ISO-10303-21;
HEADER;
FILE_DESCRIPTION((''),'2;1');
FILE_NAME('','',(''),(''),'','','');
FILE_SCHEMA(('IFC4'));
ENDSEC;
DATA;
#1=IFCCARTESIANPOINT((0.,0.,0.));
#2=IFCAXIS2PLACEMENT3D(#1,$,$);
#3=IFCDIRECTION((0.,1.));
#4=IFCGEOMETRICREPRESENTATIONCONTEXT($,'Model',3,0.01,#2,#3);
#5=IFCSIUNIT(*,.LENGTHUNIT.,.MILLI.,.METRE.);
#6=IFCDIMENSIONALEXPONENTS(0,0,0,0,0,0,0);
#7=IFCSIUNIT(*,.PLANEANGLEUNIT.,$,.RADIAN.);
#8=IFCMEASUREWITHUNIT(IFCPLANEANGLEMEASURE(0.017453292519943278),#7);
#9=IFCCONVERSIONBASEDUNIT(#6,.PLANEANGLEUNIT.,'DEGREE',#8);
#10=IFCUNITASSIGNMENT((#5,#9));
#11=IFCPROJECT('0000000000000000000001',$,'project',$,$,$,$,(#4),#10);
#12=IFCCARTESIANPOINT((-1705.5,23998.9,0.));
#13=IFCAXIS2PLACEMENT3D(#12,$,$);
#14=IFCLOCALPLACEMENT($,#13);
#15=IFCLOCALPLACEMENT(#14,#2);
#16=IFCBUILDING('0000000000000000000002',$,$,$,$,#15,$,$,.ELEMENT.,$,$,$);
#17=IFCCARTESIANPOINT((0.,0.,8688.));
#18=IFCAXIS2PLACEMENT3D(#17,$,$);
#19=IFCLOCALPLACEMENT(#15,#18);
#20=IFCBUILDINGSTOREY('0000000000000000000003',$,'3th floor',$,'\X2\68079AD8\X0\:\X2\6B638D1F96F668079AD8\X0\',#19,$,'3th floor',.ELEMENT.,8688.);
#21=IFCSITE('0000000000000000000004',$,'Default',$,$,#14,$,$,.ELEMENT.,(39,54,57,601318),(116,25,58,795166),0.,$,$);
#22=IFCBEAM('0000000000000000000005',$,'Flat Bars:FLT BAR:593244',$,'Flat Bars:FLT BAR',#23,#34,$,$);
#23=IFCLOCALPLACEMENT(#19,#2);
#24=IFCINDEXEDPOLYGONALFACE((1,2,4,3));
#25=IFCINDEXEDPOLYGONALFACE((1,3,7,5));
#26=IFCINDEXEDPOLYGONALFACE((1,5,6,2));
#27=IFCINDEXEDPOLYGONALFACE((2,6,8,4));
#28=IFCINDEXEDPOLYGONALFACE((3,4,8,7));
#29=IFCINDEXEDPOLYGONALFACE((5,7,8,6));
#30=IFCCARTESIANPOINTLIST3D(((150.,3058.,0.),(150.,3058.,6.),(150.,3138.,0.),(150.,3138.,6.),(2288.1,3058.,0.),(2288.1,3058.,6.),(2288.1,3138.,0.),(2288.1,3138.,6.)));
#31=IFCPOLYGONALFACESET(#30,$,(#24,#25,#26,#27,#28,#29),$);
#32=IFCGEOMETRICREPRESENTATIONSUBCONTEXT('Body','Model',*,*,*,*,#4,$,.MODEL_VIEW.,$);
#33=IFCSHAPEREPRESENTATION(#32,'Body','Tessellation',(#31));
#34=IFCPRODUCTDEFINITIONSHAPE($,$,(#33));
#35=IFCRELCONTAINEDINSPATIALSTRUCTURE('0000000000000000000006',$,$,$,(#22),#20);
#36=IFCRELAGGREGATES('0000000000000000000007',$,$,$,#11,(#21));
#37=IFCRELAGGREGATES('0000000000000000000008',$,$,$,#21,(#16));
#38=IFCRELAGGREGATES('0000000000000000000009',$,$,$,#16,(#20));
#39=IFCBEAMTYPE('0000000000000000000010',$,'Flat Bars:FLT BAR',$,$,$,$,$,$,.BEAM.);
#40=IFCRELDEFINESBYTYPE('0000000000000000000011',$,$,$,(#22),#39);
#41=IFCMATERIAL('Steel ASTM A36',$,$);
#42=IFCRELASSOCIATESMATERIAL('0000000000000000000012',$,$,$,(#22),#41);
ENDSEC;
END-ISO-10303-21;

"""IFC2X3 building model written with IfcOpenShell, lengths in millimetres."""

from ifc_helpers import new_model, entity, si_unit, converted_unit, direction, frame, origin, origin_2d_with_axis, place, context, subcontext, project, spatial, rectangle, extrude, material, type_object, element, save


model = new_model("IFC2X3")

# Units and contexts
model_context = context("Model", 3, precision=0.01, world=origin(), true_north=direction((0.0, 1.0)))
body_context = subcontext(model_context, "Body", "Model", "MODEL_VIEW")
ifc_project = project(units=[si_unit("LENGTHUNIT", "METRE", prefix="MILLI"), converted_unit("PLANEANGLEUNIT", "DEGREE", entity("IfcPlaneAngleMeasure", 0.017453292519943278), si_unit("PLANEANGLEUNIT", "RADIAN"), dimensions=[0, 0, 0, 0, 0, 0, 0])], contexts=[model_context])

# Site, building, storey
site_placement = place(None, frame((-1705.5, 23998.9, 0.0)))
site = spatial("IfcSite", under=ifc_project, at=site_placement, Name="Default", CompositionType="ELEMENT", RefLatitude=(39, 54, 57, 601318), RefLongitude=(116, 25, 58, 795166), RefElevation=0.0)
building_placement = place(site_placement, origin())
building = spatial("IfcBuilding", under=site, at=building_placement, CompositionType="ELEMENT")
storey_placement = place(building_placement, frame((0.0, 0.0, 8688.0)))
storey = spatial("IfcBuildingStorey", under=building, at=storey_placement, Name="3th floor", ObjectType="标高:正负零标高", LongName="3th floor", CompositionType="ELEMENT", Elevation=8688.0)

# Beam
ifc_material_1 = material(Name="Steel ASTM A36")
beam_type_1 = type_object("IfcBeamType", Name="Flat Bars:FLT BAR", PredefinedType="BEAM")
beam_1_placement = place(storey_placement, frame((150.0, 3098.0, 6.0)))
element("IfcBeam", 1, at=beam_1_placement, inside=storey, type_object=beam_type_1, material=ifc_material_1, Name="Flat Bars:FLT BAR:593244", ObjectType="Flat Bars:FLT BAR", context=body_context, shape_type="SweptSolid", body=[
    extrude(rectangle(XDim=6.0, YDim=80.0, at=origin_2d_with_axis()), frame((0.0, 0.0, -3.0), z_axis=(1.0, 0.0, 0.0), x_axis=(0.0, 0.0, -1.0)), (0.0, 0.0, 1.0), 2138.1),
])

save(model, "model.ifc")
